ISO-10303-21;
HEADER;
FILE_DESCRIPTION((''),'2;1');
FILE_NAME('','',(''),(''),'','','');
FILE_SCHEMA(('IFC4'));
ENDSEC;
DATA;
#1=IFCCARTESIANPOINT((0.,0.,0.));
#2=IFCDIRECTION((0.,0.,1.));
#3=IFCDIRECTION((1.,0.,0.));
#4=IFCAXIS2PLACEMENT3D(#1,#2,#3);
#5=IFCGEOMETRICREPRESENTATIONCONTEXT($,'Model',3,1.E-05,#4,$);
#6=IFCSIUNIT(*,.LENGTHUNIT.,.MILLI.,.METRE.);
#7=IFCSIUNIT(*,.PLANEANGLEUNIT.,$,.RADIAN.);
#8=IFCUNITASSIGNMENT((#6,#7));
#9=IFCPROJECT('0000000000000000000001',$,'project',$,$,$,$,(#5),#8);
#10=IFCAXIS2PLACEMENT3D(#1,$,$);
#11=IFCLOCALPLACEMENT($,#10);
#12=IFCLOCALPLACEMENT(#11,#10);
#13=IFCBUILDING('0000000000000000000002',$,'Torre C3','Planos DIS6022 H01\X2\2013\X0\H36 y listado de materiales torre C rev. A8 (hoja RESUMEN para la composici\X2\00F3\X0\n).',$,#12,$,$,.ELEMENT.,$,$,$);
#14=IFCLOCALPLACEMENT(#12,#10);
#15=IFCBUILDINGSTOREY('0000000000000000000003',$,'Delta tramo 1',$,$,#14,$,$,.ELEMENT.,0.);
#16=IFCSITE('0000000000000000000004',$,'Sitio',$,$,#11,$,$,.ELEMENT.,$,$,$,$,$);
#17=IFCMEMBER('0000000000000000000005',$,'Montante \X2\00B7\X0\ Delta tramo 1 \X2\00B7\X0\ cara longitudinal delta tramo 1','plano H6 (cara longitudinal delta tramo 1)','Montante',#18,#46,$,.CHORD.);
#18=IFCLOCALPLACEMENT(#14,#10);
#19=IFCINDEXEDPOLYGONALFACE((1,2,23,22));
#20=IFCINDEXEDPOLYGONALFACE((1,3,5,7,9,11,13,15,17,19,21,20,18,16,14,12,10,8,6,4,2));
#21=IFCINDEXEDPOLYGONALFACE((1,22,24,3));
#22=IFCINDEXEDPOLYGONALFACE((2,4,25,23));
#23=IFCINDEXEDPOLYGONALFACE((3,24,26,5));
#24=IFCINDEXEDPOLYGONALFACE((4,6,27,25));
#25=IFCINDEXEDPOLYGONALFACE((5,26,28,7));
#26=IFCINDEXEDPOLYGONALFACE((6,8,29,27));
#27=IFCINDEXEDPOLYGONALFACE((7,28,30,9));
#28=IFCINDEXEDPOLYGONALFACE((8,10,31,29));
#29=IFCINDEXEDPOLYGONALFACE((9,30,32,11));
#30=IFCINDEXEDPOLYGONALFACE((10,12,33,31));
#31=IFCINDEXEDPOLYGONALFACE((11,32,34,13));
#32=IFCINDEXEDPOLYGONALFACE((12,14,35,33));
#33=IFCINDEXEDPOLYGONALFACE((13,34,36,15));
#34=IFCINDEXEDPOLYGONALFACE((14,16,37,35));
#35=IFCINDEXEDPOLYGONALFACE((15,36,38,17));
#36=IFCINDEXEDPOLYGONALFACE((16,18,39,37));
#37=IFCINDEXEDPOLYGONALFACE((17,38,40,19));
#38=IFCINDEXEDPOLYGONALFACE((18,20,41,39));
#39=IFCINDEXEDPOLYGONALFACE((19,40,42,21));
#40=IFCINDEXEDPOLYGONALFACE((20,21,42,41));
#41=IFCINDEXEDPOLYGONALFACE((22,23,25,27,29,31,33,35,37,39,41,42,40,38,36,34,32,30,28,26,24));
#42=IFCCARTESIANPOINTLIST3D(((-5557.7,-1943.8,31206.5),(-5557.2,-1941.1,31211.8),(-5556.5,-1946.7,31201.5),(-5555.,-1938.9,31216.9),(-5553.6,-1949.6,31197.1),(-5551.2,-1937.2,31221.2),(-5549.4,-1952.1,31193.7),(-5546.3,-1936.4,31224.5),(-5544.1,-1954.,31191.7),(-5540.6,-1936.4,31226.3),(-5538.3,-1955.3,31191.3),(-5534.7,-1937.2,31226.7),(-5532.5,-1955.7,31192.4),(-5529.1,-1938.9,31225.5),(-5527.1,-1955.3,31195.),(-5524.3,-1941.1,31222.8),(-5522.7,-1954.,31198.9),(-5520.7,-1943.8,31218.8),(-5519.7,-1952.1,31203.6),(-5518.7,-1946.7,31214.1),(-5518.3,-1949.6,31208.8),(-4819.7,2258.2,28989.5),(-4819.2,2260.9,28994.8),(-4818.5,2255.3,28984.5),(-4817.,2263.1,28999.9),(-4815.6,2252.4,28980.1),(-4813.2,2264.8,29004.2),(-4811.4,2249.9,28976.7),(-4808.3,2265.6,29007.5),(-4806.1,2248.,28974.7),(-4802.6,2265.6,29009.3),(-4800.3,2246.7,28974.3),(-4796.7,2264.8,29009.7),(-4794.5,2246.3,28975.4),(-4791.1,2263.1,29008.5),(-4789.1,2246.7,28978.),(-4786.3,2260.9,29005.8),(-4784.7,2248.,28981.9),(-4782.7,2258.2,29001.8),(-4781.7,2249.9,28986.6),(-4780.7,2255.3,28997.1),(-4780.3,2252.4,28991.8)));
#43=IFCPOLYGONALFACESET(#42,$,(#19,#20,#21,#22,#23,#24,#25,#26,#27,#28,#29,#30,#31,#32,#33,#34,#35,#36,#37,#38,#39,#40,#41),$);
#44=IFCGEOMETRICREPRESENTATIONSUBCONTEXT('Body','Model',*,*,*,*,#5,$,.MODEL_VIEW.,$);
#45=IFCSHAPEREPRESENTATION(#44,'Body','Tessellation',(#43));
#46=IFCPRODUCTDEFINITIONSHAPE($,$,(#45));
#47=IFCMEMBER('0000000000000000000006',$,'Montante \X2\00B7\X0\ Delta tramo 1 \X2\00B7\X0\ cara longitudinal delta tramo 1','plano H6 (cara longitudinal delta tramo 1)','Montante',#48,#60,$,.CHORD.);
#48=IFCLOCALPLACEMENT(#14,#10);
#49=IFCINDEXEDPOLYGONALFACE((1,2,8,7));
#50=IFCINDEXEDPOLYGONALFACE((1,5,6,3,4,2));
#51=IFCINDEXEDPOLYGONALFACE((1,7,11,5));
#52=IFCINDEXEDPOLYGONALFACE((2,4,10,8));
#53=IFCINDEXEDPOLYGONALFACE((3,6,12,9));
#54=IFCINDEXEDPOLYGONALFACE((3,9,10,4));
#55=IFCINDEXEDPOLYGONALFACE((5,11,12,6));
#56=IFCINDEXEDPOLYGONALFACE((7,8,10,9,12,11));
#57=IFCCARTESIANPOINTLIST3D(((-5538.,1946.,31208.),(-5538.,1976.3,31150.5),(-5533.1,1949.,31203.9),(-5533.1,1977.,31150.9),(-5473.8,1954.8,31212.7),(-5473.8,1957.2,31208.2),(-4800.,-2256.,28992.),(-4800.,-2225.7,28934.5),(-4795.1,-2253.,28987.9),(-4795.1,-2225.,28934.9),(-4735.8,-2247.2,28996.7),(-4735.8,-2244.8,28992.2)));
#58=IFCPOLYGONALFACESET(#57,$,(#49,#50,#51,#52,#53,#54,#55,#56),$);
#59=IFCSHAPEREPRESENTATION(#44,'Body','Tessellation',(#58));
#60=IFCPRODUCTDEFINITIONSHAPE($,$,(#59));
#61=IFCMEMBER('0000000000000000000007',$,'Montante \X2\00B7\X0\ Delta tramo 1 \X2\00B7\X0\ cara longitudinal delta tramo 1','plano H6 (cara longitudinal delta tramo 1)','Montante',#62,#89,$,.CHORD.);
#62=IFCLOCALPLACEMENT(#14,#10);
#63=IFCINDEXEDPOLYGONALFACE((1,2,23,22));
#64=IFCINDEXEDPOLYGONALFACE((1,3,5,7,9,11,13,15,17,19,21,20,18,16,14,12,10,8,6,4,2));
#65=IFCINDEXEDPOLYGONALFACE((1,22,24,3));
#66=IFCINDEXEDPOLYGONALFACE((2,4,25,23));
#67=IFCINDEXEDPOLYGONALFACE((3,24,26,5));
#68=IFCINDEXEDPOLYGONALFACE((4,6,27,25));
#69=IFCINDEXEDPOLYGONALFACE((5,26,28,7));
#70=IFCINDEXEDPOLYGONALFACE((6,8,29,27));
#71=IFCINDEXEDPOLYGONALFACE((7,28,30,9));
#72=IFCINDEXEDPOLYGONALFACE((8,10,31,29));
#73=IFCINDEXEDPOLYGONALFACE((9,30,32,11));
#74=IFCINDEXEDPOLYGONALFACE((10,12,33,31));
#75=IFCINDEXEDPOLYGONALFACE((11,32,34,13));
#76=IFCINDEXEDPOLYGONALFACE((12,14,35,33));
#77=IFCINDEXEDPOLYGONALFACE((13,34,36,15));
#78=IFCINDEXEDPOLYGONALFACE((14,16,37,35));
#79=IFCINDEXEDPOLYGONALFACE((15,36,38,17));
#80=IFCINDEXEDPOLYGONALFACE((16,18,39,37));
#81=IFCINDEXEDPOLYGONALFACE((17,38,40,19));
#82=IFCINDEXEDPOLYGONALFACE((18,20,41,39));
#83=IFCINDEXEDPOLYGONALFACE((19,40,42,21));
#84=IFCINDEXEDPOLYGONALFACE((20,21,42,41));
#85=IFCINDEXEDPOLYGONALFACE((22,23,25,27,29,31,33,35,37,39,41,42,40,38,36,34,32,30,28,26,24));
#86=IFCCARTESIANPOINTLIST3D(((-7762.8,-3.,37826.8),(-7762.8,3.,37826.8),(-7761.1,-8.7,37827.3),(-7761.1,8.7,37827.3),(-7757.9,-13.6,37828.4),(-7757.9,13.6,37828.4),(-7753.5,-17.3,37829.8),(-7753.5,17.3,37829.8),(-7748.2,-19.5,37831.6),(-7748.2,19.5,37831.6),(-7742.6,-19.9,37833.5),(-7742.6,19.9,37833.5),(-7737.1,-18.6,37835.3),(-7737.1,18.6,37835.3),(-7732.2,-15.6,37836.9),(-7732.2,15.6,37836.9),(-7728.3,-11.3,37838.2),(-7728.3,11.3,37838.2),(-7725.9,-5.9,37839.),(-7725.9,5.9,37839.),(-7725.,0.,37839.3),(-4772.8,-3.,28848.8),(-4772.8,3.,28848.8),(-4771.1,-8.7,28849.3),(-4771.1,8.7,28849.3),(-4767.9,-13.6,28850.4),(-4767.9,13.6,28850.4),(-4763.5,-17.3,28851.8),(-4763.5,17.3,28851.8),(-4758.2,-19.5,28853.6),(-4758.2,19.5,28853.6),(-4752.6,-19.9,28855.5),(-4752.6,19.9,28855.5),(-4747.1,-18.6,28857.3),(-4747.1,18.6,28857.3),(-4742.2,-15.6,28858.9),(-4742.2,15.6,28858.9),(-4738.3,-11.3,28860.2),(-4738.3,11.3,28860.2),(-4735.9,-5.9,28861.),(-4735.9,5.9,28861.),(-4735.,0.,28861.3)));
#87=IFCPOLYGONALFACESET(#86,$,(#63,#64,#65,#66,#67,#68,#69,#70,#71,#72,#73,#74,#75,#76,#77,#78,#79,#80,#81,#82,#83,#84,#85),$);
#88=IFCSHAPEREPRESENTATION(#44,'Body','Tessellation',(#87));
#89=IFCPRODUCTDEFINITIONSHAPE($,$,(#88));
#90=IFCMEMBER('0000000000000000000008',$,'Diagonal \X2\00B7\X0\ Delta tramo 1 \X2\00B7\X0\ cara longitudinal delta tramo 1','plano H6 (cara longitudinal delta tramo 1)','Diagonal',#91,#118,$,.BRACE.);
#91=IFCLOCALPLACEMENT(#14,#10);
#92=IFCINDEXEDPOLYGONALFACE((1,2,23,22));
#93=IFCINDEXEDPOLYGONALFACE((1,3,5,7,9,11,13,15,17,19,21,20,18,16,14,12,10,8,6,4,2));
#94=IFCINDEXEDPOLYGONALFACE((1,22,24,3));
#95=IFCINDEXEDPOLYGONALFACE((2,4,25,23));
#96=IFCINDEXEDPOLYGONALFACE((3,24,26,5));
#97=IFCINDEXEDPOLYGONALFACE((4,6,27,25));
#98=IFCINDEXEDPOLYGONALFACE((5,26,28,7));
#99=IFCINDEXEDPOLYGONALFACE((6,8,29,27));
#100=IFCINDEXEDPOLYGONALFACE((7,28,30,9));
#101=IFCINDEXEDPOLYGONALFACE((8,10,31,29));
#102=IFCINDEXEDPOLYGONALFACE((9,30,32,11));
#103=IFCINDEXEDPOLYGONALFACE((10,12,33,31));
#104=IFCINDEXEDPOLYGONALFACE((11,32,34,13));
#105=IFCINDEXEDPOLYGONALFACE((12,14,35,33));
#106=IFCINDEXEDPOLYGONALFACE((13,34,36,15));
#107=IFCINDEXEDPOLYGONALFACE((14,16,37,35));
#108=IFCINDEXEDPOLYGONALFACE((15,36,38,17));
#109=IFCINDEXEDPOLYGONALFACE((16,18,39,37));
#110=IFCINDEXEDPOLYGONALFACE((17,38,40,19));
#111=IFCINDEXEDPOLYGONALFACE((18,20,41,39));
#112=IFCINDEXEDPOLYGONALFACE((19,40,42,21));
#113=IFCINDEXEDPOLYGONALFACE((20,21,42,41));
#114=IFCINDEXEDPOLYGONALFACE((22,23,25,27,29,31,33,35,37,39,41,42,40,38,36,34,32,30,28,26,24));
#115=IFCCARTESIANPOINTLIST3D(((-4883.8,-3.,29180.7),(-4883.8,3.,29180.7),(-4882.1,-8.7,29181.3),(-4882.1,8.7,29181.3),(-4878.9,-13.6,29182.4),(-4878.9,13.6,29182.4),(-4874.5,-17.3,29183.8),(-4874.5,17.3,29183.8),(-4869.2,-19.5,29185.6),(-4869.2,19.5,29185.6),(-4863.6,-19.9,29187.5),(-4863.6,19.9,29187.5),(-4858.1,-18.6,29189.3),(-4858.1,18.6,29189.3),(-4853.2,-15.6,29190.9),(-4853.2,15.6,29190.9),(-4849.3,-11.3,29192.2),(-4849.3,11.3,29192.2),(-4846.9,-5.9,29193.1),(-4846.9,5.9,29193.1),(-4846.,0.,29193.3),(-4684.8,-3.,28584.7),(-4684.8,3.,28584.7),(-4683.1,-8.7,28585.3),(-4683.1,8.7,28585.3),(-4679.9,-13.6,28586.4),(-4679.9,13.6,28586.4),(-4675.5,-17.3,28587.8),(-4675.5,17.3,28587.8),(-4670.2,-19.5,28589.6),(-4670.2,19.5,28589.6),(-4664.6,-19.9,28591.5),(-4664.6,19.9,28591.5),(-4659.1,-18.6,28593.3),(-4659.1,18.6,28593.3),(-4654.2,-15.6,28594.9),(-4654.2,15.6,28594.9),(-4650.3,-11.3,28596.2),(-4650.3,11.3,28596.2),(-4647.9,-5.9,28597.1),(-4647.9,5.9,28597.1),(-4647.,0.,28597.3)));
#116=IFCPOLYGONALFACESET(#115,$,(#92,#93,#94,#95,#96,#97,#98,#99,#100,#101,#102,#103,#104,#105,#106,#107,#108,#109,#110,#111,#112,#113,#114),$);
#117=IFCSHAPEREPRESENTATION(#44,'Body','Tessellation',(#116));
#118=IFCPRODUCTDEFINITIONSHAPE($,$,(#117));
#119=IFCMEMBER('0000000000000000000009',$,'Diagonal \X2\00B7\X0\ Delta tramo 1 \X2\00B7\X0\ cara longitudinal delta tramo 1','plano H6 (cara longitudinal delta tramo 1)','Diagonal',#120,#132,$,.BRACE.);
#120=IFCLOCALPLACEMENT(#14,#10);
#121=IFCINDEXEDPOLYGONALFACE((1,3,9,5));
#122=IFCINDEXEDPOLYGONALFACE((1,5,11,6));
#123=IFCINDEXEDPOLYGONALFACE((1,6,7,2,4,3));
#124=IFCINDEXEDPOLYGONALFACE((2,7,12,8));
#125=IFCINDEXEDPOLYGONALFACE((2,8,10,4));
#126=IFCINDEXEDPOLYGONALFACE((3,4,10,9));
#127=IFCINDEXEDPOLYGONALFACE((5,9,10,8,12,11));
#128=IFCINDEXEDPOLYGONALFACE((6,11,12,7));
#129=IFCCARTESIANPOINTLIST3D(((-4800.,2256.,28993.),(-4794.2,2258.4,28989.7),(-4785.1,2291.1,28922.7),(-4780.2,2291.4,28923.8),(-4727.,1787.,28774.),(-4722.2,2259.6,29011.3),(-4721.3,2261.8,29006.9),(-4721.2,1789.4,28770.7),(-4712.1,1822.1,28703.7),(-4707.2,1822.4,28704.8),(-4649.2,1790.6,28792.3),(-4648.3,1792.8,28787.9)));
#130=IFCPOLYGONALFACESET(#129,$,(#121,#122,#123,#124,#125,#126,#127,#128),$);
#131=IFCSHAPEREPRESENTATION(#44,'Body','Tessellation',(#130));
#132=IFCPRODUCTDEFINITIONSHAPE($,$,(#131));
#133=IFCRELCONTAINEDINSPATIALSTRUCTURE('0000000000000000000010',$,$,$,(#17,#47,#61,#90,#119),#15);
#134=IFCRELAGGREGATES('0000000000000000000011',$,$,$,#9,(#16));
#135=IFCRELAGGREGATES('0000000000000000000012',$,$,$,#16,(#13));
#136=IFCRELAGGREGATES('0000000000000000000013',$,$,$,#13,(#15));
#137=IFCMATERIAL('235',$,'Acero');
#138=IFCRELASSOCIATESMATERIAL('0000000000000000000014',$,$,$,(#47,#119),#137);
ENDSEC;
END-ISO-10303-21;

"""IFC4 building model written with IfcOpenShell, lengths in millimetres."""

from ifc_helpers import new_model, si_unit, frame, frame_2d, origin, origin_with_axes, place, context, subcontext, project, spatial, circle, l_section, extrude, material, element, save


model = new_model("IFC4")

# Units and contexts
model_context = context("Model", 3, precision=1e-05, world=origin_with_axes())
body_context = subcontext(model_context, "Body", "Model", "MODEL_VIEW")
ifc_project = project(units=[si_unit("LENGTHUNIT", "METRE", prefix="MILLI"), si_unit("PLANEANGLEUNIT", "RADIAN")], contexts=[model_context])

# Site, building, storey
site_placement = place(None, origin())
site = spatial("IfcSite", under=ifc_project, at=site_placement, Name="Sitio", CompositionType="ELEMENT")
building_placement = place(site_placement, origin())
building = spatial("IfcBuilding", under=site, at=building_placement, Name="Torre C3", Description="Planos DIS6022 H01–H36 y listado de materiales torre C rev. A8 (hoja RESUMEN para la composición).", CompositionType="ELEMENT")
storey_placement = place(building_placement, origin())
storey = spatial("IfcBuildingStorey", under=building, at=storey_placement, Name="Delta tramo 1", CompositionType="ELEMENT", Elevation=0.0)

# Members
member_1_placement = place(storey_placement, frame((-4800.0, 2256.0, 28992.0), z_axis=(-0.153495, -0.873966, 0.46111), x_axis=(0.276036, -0.485987, -0.829229)))
element("IfcMember", 1, at=member_1_placement, inside=storey, Name="Montante · Delta tramo 1 · cara longitudinal delta tramo 1", Description="plano H6 (cara longitudinal delta tramo 1)", ObjectType="Montante", PredefinedType="CHORD", context=body_context, shape_type="SweptSolid", body=[
    extrude(circle(Radius=20.0), None, (0.0, 0.0, 1.0), 4808.0),
])
ifc_material_1 = material(Name="235", Category="Acero")
member_2_placement = place(storey_placement, frame((-4800.0, -2256.0, 28992.0), z_axis=(-0.15351, 0.87405, 0.460946), x_axis=(0.988147, 0.135785, 0.071609)))
element("IfcMember", 2, at=member_2_placement, inside=storey, material=ifc_material_1, Name="Montante · Delta tramo 1 · cara longitudinal delta tramo 1", Description="plano H6 (cara longitudinal delta tramo 1)", ObjectType="Montante", PredefinedType="CHORD", context=body_context, shape_type="SweptSolid", body=[
    extrude(l_section(Depth=65.0, Width=65.0, Thickness=5.0, at=frame_2d((32.5, 32.5))), None, (0.0, 0.0, 1.0), 4807.5),
])
member_3_placement = place(storey_placement, frame((-4754.0, 0.0, 28855.0), z_axis=(-0.315974, 0.0, 0.948768), x_axis=(0.948768, 0.0, 0.315974)))
element("IfcMember", 3, at=member_3_placement, inside=storey, Name="Montante · Delta tramo 1 · cara longitudinal delta tramo 1", Description="plano H6 (cara longitudinal delta tramo 1)", ObjectType="Montante", PredefinedType="CHORD", context=body_context, shape_type="SweptSolid", body=[
    extrude(circle(Radius=20.0), None, (0.0, 0.0, 1.0), 9462.8),
])
member_4_placement = place(storey_placement, frame((-4666.0, 0.0, 28591.0), z_axis=(-0.316705, 0.0, 0.948524), x_axis=(0.948524, 0.0, 0.316705)))
element("IfcMember", 4, at=member_4_placement, inside=storey, Name="Diagonal · Delta tramo 1 · cara longitudinal delta tramo 1", Description="plano H6 (cara longitudinal delta tramo 1)", ObjectType="Diagonal", PredefinedType="BRACE", context=body_context, shape_type="SweptSolid", body=[
    extrude(circle(Radius=20.0), None, (0.0, 0.0, 1.0), 628.3),
])
member_5_placement = place(storey_placement, frame((-4727.0, 1787.0, 28774.0), z_axis=(-0.13965, 0.897206, 0.418951), x_axis=(0.972489, 0.044604, 0.22864)))
element("IfcMember", 5, at=member_5_placement, inside=storey, material=ifc_material_1, Name="Diagonal · Delta tramo 1 · cara longitudinal delta tramo 1", Description="plano H6 (cara longitudinal delta tramo 1)", ObjectType="Diagonal", PredefinedType="BRACE", context=body_context, shape_type="SweptSolid", body=[
    extrude(l_section(Depth=80.0, Width=80.0, Thickness=5.0, at=frame_2d((40.0, 40.0))), None, (0.0, 0.0, 1.0), 522.7),
])

save(model, "model.ifc")
